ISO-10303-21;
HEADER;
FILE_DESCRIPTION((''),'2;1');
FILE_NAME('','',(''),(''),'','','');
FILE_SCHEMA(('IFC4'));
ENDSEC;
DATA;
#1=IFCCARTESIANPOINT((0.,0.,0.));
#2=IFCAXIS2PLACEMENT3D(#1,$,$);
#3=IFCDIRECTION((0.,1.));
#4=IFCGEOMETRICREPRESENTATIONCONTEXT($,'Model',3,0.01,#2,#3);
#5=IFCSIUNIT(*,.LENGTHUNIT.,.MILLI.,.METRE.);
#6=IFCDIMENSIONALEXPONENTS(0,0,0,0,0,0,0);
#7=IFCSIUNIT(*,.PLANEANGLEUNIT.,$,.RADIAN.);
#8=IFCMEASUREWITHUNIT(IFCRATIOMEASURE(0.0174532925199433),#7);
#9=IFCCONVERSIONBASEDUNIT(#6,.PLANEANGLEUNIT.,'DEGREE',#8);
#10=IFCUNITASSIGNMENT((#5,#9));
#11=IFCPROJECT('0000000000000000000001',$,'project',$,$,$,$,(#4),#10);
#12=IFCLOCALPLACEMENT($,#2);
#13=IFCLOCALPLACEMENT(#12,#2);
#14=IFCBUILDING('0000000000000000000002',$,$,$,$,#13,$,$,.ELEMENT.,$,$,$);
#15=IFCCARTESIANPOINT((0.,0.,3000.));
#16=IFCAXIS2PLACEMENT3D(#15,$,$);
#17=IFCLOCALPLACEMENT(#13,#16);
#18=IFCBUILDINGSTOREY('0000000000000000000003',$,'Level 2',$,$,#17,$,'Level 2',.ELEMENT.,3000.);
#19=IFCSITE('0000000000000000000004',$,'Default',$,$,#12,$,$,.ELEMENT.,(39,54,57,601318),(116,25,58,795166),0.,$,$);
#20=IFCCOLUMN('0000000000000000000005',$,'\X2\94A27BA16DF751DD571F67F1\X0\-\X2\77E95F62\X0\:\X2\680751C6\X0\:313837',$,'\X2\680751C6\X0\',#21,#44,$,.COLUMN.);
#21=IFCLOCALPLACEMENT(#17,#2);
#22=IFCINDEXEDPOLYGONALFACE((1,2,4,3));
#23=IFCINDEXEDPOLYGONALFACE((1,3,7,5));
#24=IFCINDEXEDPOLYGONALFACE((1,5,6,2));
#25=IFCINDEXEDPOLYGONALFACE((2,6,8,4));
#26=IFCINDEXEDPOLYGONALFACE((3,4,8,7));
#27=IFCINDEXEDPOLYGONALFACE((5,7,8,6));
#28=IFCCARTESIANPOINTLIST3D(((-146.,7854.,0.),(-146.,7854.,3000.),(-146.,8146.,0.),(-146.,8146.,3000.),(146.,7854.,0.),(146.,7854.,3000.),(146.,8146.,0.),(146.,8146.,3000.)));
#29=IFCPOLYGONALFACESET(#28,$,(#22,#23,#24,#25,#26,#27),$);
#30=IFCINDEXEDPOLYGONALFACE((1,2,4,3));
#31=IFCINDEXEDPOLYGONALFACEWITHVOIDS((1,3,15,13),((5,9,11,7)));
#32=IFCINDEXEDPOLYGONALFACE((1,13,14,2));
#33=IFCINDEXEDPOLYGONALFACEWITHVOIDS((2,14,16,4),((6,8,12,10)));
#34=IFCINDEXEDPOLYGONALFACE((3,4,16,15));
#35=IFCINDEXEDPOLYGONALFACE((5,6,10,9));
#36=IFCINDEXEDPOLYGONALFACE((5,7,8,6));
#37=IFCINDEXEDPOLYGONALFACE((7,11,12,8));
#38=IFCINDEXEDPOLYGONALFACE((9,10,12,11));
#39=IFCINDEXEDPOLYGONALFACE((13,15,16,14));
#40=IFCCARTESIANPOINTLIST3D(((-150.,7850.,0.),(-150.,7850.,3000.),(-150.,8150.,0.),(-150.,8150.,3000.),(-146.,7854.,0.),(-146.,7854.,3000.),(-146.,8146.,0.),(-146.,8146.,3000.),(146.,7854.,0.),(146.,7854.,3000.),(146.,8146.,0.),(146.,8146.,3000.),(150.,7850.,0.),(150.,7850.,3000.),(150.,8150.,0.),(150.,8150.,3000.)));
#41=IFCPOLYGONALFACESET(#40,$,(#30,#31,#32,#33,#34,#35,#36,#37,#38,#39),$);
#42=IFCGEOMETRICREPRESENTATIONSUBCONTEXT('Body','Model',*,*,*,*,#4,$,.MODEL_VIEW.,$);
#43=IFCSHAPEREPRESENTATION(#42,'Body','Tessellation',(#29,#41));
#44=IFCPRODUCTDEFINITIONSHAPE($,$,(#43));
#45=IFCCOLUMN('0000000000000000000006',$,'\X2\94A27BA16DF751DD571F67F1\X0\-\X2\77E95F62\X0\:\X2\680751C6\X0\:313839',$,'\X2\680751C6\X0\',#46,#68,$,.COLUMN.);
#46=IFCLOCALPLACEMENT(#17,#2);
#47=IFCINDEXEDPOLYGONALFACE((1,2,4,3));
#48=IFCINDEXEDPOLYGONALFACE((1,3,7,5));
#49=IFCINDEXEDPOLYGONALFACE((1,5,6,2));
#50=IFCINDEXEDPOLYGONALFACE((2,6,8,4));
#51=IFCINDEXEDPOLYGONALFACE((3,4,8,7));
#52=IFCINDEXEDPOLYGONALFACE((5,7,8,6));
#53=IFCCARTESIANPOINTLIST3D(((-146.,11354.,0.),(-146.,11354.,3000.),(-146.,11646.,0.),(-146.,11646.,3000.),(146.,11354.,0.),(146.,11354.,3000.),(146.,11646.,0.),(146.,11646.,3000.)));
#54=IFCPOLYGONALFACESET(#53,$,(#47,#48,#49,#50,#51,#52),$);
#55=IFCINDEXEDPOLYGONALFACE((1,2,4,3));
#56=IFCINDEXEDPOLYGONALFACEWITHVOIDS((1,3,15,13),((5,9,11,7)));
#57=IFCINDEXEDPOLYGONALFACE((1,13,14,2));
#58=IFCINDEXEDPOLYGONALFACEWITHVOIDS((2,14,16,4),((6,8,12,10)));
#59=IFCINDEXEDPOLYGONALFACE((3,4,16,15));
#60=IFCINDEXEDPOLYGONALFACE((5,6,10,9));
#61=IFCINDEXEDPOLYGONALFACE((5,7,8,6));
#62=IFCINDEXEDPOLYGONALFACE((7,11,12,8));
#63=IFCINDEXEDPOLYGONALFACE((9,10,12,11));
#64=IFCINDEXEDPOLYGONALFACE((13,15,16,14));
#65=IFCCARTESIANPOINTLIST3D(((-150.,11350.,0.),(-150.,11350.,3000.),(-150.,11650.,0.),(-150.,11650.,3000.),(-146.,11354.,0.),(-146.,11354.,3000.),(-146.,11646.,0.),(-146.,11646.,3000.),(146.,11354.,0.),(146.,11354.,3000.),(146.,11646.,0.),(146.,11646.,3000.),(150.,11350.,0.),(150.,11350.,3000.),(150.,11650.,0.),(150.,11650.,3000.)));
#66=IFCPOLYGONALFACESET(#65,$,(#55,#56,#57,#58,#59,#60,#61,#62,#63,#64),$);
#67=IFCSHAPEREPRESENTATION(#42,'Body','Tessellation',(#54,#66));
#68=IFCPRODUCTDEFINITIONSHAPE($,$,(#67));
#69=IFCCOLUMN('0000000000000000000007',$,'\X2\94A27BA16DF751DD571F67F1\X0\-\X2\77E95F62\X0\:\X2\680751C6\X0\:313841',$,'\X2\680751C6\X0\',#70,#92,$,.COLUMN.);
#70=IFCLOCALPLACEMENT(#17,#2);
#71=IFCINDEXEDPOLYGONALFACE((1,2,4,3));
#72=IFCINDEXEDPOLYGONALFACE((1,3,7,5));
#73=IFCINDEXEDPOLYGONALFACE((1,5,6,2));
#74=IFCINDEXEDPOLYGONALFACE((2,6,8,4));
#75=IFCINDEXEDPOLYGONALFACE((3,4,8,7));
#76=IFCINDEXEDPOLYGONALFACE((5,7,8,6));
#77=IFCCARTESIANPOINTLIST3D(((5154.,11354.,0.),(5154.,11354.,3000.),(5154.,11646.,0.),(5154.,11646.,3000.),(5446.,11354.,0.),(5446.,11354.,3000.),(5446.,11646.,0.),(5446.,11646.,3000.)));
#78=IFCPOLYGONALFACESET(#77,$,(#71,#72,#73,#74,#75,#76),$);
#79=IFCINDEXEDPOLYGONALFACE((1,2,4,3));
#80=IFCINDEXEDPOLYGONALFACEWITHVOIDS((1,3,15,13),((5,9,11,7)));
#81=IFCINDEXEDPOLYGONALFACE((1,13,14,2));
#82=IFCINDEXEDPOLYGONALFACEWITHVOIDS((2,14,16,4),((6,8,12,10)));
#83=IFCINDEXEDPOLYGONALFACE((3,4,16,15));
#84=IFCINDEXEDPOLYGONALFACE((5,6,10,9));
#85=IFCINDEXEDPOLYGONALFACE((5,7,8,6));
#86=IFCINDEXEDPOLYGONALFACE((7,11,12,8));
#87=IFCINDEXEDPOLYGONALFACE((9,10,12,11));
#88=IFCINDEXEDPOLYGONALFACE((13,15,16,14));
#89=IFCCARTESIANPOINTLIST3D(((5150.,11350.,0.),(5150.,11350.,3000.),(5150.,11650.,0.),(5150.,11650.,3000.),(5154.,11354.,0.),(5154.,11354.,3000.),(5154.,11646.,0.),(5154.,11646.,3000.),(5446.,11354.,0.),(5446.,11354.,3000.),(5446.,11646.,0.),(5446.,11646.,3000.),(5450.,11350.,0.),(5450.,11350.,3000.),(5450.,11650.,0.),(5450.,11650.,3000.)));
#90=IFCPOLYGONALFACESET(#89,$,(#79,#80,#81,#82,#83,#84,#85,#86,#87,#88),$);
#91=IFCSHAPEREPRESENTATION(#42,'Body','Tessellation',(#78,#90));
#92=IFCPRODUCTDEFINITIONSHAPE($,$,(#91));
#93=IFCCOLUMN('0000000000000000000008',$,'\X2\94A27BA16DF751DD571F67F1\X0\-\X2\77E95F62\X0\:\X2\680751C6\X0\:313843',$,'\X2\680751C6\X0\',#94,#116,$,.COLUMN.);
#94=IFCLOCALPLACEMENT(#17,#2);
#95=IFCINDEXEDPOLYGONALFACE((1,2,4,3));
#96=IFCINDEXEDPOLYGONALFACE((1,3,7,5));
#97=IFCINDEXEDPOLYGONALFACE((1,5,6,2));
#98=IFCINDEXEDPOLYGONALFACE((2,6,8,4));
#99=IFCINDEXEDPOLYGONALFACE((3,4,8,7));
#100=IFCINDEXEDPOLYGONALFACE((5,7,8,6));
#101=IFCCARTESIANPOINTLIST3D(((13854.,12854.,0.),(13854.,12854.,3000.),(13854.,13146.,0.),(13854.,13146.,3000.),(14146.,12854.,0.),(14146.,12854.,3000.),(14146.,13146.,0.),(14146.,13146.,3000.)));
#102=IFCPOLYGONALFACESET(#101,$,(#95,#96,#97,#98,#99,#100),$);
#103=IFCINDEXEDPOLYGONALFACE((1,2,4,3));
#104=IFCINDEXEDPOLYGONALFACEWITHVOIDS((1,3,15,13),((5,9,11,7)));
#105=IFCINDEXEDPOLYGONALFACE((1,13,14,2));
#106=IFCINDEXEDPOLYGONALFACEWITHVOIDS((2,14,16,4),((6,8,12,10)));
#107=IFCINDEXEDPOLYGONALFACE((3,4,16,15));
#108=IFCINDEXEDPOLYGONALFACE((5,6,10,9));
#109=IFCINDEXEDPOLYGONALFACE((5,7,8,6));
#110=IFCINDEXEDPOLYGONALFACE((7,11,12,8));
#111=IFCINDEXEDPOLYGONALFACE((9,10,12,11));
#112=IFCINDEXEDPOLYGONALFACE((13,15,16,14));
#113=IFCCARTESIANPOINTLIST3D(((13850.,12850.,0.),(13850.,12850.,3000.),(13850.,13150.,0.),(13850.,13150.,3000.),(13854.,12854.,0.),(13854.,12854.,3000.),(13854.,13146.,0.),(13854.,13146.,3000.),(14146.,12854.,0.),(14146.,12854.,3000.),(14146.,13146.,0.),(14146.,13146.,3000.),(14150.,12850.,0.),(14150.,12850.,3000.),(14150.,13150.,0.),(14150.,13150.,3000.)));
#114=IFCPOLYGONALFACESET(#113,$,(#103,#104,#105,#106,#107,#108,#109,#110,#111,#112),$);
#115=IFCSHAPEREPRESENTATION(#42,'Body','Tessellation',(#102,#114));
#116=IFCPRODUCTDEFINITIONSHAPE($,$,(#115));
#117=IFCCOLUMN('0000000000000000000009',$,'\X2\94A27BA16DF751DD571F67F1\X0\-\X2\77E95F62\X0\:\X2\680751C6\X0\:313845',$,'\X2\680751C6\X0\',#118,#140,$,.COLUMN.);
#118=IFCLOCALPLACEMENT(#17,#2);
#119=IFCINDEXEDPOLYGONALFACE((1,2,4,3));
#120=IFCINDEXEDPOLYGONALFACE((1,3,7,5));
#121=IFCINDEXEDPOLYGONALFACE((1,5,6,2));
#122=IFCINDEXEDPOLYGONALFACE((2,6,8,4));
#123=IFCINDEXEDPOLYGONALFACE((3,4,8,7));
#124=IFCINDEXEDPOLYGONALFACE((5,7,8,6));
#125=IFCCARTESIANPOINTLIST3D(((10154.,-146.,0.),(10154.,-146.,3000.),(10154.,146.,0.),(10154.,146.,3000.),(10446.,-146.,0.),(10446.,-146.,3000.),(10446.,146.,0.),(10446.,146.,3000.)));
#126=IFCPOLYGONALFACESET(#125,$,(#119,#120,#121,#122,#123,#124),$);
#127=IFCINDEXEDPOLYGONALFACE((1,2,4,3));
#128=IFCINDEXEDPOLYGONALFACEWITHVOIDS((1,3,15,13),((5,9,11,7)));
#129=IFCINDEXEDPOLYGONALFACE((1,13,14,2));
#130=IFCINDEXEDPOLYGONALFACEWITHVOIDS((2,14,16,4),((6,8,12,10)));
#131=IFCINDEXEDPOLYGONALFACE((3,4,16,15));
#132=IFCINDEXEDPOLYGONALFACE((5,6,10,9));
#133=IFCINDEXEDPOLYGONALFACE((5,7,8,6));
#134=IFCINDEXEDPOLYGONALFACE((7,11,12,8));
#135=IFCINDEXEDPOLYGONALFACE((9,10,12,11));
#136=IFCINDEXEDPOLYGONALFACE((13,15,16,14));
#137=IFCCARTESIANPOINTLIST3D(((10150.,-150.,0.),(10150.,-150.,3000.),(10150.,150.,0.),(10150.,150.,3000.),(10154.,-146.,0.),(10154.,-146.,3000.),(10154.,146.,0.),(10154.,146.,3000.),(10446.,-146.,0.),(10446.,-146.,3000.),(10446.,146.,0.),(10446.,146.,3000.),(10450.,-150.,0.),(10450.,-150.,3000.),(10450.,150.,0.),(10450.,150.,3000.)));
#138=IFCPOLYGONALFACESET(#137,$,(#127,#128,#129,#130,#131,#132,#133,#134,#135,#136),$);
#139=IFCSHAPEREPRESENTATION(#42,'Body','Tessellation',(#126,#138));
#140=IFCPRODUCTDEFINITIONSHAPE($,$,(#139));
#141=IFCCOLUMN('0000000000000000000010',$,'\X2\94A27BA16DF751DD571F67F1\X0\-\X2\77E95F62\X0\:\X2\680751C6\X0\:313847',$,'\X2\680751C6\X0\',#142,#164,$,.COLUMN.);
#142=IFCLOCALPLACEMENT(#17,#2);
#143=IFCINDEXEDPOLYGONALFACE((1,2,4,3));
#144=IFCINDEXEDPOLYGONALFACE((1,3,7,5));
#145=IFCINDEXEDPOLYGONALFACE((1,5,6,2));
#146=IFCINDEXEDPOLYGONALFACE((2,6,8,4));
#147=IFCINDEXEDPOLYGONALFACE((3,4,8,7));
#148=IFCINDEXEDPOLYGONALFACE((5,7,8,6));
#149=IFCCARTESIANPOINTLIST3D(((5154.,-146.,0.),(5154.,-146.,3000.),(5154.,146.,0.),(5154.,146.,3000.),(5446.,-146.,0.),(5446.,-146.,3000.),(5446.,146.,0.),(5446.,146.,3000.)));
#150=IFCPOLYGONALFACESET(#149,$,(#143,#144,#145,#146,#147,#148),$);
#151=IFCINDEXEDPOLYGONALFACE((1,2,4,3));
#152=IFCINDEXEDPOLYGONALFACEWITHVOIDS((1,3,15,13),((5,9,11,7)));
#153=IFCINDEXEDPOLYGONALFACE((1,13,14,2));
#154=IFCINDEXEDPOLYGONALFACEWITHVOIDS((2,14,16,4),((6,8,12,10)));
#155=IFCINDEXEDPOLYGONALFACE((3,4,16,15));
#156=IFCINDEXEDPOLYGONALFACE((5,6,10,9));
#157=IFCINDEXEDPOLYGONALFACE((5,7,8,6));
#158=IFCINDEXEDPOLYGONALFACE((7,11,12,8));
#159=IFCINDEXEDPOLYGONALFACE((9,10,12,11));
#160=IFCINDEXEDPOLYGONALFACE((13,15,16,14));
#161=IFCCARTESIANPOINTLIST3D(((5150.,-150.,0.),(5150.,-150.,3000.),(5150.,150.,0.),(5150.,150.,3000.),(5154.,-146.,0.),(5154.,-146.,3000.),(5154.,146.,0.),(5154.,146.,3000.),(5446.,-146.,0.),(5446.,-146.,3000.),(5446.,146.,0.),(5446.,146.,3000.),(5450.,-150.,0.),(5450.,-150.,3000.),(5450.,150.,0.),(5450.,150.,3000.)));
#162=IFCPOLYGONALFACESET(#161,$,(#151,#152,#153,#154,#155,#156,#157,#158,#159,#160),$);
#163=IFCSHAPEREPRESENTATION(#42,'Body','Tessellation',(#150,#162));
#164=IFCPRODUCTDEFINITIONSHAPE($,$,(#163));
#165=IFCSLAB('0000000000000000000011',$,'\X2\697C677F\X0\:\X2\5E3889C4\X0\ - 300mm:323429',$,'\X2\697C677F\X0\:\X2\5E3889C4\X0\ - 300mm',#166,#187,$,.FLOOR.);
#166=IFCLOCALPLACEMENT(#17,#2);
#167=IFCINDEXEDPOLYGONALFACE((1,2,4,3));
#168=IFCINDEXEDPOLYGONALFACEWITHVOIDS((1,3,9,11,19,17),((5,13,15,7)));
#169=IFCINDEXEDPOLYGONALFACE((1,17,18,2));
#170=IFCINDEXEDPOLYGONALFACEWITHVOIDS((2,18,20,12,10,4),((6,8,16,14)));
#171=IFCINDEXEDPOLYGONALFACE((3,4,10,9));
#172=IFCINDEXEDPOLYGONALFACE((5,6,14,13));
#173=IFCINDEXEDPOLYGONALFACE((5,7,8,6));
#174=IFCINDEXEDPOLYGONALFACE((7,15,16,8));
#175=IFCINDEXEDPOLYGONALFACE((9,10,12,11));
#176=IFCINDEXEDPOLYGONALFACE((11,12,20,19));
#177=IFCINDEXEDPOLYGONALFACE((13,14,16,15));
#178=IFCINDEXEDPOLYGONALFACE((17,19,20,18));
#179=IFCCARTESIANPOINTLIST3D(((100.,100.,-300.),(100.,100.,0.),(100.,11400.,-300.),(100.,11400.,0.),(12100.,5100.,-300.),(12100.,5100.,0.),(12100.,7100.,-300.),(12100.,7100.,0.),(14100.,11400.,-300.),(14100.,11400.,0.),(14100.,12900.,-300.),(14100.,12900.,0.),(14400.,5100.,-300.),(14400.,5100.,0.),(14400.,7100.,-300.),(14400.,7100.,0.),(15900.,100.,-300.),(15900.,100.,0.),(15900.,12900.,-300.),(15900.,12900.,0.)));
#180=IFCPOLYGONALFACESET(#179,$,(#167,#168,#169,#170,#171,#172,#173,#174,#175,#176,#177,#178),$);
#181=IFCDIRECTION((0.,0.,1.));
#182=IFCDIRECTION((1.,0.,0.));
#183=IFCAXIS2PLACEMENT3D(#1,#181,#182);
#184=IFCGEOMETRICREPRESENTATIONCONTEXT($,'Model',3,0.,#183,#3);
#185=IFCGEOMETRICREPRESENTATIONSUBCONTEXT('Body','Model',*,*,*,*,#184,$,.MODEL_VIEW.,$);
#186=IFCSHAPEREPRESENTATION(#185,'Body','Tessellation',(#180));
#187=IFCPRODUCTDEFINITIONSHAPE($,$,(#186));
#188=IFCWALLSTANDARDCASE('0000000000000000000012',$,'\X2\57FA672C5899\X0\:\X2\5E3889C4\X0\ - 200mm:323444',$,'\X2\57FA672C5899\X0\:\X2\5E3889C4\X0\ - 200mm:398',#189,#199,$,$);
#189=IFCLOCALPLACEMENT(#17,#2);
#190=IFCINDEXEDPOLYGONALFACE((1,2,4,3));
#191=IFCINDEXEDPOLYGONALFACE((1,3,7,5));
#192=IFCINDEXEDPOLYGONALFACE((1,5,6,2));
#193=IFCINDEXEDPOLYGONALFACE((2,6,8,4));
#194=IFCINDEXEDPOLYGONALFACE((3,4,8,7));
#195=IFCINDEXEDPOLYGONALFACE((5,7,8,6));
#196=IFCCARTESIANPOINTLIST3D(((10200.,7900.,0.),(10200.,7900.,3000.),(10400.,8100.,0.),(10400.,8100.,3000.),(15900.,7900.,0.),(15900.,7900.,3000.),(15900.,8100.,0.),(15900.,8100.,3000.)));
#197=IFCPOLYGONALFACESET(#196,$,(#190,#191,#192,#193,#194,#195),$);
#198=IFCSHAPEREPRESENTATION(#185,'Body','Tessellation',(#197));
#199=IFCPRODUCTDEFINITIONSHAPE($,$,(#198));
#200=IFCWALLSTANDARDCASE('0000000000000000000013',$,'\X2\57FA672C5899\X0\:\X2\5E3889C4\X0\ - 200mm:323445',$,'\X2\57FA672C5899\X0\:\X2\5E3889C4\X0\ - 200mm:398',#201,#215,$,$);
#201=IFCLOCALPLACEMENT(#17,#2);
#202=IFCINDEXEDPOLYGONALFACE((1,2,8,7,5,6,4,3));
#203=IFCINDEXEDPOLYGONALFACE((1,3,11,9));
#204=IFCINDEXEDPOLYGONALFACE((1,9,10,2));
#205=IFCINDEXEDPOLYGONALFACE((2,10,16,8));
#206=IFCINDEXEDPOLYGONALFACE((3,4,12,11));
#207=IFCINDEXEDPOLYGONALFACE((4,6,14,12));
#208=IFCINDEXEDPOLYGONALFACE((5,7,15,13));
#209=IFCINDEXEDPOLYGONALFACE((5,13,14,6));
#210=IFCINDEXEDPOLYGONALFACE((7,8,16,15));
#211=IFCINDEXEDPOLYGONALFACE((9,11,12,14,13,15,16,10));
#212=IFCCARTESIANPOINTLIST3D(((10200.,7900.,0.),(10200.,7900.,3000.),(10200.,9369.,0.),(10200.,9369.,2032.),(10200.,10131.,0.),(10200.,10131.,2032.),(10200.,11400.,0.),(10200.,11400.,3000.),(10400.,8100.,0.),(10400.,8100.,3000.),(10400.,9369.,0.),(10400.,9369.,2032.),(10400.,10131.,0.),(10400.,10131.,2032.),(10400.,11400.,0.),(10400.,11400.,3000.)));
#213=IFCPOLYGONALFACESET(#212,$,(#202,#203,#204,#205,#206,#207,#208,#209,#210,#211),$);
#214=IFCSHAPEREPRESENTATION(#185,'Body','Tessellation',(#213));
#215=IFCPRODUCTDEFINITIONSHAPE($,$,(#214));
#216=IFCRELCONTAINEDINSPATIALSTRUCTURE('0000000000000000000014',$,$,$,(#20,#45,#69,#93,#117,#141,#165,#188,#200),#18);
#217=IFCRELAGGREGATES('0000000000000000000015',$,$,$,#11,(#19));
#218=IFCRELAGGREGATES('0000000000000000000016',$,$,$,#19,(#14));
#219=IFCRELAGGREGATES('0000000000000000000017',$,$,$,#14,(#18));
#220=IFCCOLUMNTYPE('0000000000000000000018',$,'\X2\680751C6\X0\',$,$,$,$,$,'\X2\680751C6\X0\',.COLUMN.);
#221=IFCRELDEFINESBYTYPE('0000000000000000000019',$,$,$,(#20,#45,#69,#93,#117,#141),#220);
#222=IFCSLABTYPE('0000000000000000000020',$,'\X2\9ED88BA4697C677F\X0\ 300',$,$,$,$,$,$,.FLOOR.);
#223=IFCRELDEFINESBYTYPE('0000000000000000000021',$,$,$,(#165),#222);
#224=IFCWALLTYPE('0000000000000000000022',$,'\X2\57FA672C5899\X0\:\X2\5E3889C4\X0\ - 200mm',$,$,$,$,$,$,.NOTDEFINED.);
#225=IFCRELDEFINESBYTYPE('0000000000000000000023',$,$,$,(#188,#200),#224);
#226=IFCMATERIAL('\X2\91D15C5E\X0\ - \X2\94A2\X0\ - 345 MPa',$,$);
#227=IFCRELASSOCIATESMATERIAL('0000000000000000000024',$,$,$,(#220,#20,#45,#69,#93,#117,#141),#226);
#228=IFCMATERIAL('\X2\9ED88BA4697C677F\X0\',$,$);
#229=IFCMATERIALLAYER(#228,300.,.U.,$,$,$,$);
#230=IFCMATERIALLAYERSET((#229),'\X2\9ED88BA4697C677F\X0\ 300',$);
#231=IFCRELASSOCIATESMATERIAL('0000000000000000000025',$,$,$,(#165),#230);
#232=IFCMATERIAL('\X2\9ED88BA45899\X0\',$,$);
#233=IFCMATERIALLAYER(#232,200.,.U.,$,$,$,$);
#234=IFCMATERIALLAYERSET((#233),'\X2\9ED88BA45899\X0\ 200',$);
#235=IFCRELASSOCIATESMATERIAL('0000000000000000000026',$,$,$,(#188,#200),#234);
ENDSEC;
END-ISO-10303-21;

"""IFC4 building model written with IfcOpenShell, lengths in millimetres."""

from ifc_helpers import new_model, entity, si_unit, converted_unit, direction, frame, origin, origin_with_axes, origin_2d_with_axis, place, context, subcontext, project, spatial, polyline, rectangle, outline, extrude, source, transform, mapped, material, layer, layer_set, layer_usage, type_object, type_shapes, element, save


model = new_model("IFC4")

# Units and contexts
model_context_1 = context("Model", 3, precision=0.01, world=origin(), true_north=direction((0.0, 1.0)))
model_context_2 = context("Model", 3, precision=0.0, world=origin_with_axes(), true_north=direction((0.0, 1.0)))
body_context_1 = subcontext(model_context_1, "Body", "Model", "MODEL_VIEW")
body_context_2 = subcontext(model_context_2, "Body", "Model", "MODEL_VIEW")
ifc_project = project(units=[si_unit("LENGTHUNIT", "METRE", prefix="MILLI"), converted_unit("PLANEANGLEUNIT", "DEGREE", entity("IfcRatioMeasure", 0.0174532925199433), si_unit("PLANEANGLEUNIT", "RADIAN"), dimensions=[0, 0, 0, 0, 0, 0, 0])], contexts=[model_context_1])

# Site, building, storey
site_placement = place(None, origin())
site = spatial("IfcSite", under=ifc_project, at=site_placement, Name="Default", CompositionType="ELEMENT", RefLatitude=(39, 54, 57, 601318), RefLongitude=(116, 25, 58, 795166), RefElevation=0.0)
building_placement = place(site_placement, origin())
building = spatial("IfcBuilding", under=site, at=building_placement, CompositionType="ELEMENT")
storey_placement = place(building_placement, frame((0.0, 0.0, 3000.0)))
storey = spatial("IfcBuildingStorey", under=building, at=storey_placement, Name="Level 2", LongName="Level 2", CompositionType="ELEMENT", Elevation=3000.0)

# Columns
ifc_material_1 = material(Name="金属 - 钢 - 345 MPa")
column_type = type_object("IfcColumnType", Name="标准", ElementType="标准", PredefinedType="COLUMN", material=ifc_material_1)
shared_shape = source(origin(), body_context_1, "Body", "SweptSolid", [
    extrude(rectangle(XDim=292.0, YDim=292.0, at=origin_2d_with_axis()), frame((150.0, 150.0, 0.0), z_axis=(0.0, 0.0, 1.0), x_axis=(-1.0, 0.0, 0.0)), (0.0, 0.0, 1.0), 3000.0),
    extrude(outline(polyline([(-150.0, -150.0), (150.0, -150.0), (150.0, 150.0), (-150.0, 150.0), (-150.0, -150.0)]), holes=[polyline([(-146.0, -146.0), (-146.0, 146.0), (146.0, 146.0), (146.0, -146.0), (-146.0, -146.0)])]), frame((150.0, 150.0, 0.0), z_axis=(0.0, 0.0, 1.0), x_axis=(-1.0, 0.0, 0.0)), (0.0, 0.0, 1.0), 3000.0),
])
type_shapes(column_type, [shared_shape])
for number, where, name in (
    (1, (-150.0, 7850.0, 0.0), "钢管混凝土柱-矩形:标准:313837"),
    (2, (-150.0, 11350.0, 0.0), "钢管混凝土柱-矩形:标准:313839"),
    (3, (5150.0, 11350.0, 0.0), "钢管混凝土柱-矩形:标准:313841"),
    (4, (13850.0, 12850.0, 0.0), "钢管混凝土柱-矩形:标准:313843"),
    (5, (10150.0, -150.0, 0.0), "钢管混凝土柱-矩形:标准:313845"),
    (6, (5150.0, -150.0, 0.0), "钢管混凝土柱-矩形:标准:313847"),
):
    element("IfcColumn", number, at=place(storey_placement, frame(where)), inside=storey, type_object=column_type, material=ifc_material_1, Name=name, ObjectType="标准", PredefinedType="COLUMN", context=body_context_1, shape_type="MappedRepresentation", body=[
        mapped(shared_shape, transform((0.0, 0.0, 0.0), scale=1.0)),
    ])

# Slab, opening
ifc_material_2 = material(Name="默认楼板")
ifc_layer_1 = layer(ifc_material_2, 300.0, ventilated="UNKNOWN")
ifc_layer_set_1 = layer_set([ifc_layer_1], Name="默认楼板 300")
ifc_layer_usage_1 = layer_usage(ifc_layer_set_1, "AXIS3", "NEGATIVE", 300.0)
slab_type = type_object("IfcSlabType", Name="默认楼板 300", PredefinedType="FLOOR")
placement_1 = place(None, origin_with_axes())
placement_2 = place(placement_1, origin_with_axes())
placement_3 = place(placement_2, frame((0.0, 0.0, 3000.0), z_axis=(0.0, 0.0, 1.0), x_axis=(1.0, 0.0, 0.0)))
slab_placement = place(placement_3, frame((15900.0, 12900.0, -300.0), z_axis=(0.0, 0.0, 1.0), x_axis=(1.0, 0.0, 0.0)))
slab = element("IfcSlab", 7, at=slab_placement, inside=storey, type_object=slab_type, material=ifc_layer_usage_1, Name="楼板:常规 - 300mm:323429", ObjectType="楼板:常规 - 300mm", PredefinedType="FLOOR", context=body_context_2, shape_type="SweptSolid", body=[
    extrude(outline(polyline([(0.0, 0.0), (-1800.0, 0.0), (-1800.0, -1500.0), (-15800.0, -1500.0), (-15800.0, -12800.0), (0.0, -12800.0), (0.0, 0.0)])), origin_with_axes(), (0.0, 0.0, 1.0), 300.0),
])
opening_1_placement = place(slab_placement, origin_with_axes())
element("IfcOpeningElement", 8, at=opening_1_placement, cuts=slab, context=body_context_2, shape_type="SweptSolid", body=[
    extrude(outline(polyline([(-3800.0, -7800.0), (-1500.0, -7800.0), (-1500.0, -5800.0), (-3800.0, -5800.0), (-3800.0, -7800.0)])), origin_with_axes(), (0.0, 0.0, 1.0), 300.0),
])

# Wall
ifc_material_3 = material(Name="默认墙")
ifc_layer_2 = layer(ifc_material_3, 200.0, ventilated="UNKNOWN")
ifc_layer_set_2 = layer_set([ifc_layer_2], Name="默认墙 200")
ifc_layer_usage_2 = layer_usage(ifc_layer_set_2, "AXIS2", "POSITIVE", -100.0)
wall_type = type_object("IfcWallType", Name="基本墙:常规 - 200mm", PredefinedType="NOTDEFINED")
wall_1_placement = place(placement_3, frame((10300.0, 8000.0, 0.0), z_axis=(0.0, 0.0, 1.0), x_axis=(1.0, 0.0, 0.0)))
element("IfcWallStandardCase", 9, at=wall_1_placement, inside=storey, type_object=wall_type, material=ifc_layer_usage_2, Name="基本墙:常规 - 200mm:323444", ObjectType="基本墙:常规 - 200mm:398", context=body_context_2, shape_type="SweptSolid", body=[
    extrude(outline(polyline([(-100.0, -100.0), (5600.0, -100.0), (5600.0, 100.0), (100.0, 100.0), (-100.0, -100.0)])), origin_with_axes(), (0.0, 0.0, 1.0), 3000.0),
])

# Wall, opening
ifc_layer_usage_3 = layer_usage(ifc_layer_set_2, "AXIS2", "POSITIVE", -100.0)
wall_2_placement = place(placement_3, frame((10300.0, 11500.0, 0.0), z_axis=(0.0, 0.0, 1.0), x_axis=(0.0, -1.0, 0.0)))
wall_2 = element("IfcWallStandardCase", 10, at=wall_2_placement, inside=storey, type_object=wall_type, material=ifc_layer_usage_3, Name="基本墙:常规 - 200mm:323445", ObjectType="基本墙:常规 - 200mm:398", context=body_context_2, shape_type="SweptSolid", body=[
    extrude(outline(polyline([(100.0, -100.0), (3600.0, -100.0), (3400.0, 100.0), (100.0, 100.0), (100.0, -100.0)])), origin_with_axes(), (0.0, 0.0, 1.0), 3000.0),
])
opening_2_placement = place(wall_2_placement, frame((1750.0, 0.0, 0.0), z_axis=(0.0, 0.0, 1.0), x_axis=(1.0, 0.0, 0.0)))
element("IfcOpeningElement", 11, at=opening_2_placement, cuts=wall_2, context=body_context_2, shape_type="SweptSolid", body=[
    extrude(outline(polyline([(-381.0, -2032.0), (381.0, -2032.0), (381.0, 0.0), (-381.0, 0.0), (-381.0, -2032.0)])), frame((0.0, 100.0, 0.0), z_axis=(0.0, -1.0, 0.0), x_axis=(-1.0, 0.0, 0.0)), (0.0, 0.0, 1.0), 200.0),
])

save(model, "model.ifc")
